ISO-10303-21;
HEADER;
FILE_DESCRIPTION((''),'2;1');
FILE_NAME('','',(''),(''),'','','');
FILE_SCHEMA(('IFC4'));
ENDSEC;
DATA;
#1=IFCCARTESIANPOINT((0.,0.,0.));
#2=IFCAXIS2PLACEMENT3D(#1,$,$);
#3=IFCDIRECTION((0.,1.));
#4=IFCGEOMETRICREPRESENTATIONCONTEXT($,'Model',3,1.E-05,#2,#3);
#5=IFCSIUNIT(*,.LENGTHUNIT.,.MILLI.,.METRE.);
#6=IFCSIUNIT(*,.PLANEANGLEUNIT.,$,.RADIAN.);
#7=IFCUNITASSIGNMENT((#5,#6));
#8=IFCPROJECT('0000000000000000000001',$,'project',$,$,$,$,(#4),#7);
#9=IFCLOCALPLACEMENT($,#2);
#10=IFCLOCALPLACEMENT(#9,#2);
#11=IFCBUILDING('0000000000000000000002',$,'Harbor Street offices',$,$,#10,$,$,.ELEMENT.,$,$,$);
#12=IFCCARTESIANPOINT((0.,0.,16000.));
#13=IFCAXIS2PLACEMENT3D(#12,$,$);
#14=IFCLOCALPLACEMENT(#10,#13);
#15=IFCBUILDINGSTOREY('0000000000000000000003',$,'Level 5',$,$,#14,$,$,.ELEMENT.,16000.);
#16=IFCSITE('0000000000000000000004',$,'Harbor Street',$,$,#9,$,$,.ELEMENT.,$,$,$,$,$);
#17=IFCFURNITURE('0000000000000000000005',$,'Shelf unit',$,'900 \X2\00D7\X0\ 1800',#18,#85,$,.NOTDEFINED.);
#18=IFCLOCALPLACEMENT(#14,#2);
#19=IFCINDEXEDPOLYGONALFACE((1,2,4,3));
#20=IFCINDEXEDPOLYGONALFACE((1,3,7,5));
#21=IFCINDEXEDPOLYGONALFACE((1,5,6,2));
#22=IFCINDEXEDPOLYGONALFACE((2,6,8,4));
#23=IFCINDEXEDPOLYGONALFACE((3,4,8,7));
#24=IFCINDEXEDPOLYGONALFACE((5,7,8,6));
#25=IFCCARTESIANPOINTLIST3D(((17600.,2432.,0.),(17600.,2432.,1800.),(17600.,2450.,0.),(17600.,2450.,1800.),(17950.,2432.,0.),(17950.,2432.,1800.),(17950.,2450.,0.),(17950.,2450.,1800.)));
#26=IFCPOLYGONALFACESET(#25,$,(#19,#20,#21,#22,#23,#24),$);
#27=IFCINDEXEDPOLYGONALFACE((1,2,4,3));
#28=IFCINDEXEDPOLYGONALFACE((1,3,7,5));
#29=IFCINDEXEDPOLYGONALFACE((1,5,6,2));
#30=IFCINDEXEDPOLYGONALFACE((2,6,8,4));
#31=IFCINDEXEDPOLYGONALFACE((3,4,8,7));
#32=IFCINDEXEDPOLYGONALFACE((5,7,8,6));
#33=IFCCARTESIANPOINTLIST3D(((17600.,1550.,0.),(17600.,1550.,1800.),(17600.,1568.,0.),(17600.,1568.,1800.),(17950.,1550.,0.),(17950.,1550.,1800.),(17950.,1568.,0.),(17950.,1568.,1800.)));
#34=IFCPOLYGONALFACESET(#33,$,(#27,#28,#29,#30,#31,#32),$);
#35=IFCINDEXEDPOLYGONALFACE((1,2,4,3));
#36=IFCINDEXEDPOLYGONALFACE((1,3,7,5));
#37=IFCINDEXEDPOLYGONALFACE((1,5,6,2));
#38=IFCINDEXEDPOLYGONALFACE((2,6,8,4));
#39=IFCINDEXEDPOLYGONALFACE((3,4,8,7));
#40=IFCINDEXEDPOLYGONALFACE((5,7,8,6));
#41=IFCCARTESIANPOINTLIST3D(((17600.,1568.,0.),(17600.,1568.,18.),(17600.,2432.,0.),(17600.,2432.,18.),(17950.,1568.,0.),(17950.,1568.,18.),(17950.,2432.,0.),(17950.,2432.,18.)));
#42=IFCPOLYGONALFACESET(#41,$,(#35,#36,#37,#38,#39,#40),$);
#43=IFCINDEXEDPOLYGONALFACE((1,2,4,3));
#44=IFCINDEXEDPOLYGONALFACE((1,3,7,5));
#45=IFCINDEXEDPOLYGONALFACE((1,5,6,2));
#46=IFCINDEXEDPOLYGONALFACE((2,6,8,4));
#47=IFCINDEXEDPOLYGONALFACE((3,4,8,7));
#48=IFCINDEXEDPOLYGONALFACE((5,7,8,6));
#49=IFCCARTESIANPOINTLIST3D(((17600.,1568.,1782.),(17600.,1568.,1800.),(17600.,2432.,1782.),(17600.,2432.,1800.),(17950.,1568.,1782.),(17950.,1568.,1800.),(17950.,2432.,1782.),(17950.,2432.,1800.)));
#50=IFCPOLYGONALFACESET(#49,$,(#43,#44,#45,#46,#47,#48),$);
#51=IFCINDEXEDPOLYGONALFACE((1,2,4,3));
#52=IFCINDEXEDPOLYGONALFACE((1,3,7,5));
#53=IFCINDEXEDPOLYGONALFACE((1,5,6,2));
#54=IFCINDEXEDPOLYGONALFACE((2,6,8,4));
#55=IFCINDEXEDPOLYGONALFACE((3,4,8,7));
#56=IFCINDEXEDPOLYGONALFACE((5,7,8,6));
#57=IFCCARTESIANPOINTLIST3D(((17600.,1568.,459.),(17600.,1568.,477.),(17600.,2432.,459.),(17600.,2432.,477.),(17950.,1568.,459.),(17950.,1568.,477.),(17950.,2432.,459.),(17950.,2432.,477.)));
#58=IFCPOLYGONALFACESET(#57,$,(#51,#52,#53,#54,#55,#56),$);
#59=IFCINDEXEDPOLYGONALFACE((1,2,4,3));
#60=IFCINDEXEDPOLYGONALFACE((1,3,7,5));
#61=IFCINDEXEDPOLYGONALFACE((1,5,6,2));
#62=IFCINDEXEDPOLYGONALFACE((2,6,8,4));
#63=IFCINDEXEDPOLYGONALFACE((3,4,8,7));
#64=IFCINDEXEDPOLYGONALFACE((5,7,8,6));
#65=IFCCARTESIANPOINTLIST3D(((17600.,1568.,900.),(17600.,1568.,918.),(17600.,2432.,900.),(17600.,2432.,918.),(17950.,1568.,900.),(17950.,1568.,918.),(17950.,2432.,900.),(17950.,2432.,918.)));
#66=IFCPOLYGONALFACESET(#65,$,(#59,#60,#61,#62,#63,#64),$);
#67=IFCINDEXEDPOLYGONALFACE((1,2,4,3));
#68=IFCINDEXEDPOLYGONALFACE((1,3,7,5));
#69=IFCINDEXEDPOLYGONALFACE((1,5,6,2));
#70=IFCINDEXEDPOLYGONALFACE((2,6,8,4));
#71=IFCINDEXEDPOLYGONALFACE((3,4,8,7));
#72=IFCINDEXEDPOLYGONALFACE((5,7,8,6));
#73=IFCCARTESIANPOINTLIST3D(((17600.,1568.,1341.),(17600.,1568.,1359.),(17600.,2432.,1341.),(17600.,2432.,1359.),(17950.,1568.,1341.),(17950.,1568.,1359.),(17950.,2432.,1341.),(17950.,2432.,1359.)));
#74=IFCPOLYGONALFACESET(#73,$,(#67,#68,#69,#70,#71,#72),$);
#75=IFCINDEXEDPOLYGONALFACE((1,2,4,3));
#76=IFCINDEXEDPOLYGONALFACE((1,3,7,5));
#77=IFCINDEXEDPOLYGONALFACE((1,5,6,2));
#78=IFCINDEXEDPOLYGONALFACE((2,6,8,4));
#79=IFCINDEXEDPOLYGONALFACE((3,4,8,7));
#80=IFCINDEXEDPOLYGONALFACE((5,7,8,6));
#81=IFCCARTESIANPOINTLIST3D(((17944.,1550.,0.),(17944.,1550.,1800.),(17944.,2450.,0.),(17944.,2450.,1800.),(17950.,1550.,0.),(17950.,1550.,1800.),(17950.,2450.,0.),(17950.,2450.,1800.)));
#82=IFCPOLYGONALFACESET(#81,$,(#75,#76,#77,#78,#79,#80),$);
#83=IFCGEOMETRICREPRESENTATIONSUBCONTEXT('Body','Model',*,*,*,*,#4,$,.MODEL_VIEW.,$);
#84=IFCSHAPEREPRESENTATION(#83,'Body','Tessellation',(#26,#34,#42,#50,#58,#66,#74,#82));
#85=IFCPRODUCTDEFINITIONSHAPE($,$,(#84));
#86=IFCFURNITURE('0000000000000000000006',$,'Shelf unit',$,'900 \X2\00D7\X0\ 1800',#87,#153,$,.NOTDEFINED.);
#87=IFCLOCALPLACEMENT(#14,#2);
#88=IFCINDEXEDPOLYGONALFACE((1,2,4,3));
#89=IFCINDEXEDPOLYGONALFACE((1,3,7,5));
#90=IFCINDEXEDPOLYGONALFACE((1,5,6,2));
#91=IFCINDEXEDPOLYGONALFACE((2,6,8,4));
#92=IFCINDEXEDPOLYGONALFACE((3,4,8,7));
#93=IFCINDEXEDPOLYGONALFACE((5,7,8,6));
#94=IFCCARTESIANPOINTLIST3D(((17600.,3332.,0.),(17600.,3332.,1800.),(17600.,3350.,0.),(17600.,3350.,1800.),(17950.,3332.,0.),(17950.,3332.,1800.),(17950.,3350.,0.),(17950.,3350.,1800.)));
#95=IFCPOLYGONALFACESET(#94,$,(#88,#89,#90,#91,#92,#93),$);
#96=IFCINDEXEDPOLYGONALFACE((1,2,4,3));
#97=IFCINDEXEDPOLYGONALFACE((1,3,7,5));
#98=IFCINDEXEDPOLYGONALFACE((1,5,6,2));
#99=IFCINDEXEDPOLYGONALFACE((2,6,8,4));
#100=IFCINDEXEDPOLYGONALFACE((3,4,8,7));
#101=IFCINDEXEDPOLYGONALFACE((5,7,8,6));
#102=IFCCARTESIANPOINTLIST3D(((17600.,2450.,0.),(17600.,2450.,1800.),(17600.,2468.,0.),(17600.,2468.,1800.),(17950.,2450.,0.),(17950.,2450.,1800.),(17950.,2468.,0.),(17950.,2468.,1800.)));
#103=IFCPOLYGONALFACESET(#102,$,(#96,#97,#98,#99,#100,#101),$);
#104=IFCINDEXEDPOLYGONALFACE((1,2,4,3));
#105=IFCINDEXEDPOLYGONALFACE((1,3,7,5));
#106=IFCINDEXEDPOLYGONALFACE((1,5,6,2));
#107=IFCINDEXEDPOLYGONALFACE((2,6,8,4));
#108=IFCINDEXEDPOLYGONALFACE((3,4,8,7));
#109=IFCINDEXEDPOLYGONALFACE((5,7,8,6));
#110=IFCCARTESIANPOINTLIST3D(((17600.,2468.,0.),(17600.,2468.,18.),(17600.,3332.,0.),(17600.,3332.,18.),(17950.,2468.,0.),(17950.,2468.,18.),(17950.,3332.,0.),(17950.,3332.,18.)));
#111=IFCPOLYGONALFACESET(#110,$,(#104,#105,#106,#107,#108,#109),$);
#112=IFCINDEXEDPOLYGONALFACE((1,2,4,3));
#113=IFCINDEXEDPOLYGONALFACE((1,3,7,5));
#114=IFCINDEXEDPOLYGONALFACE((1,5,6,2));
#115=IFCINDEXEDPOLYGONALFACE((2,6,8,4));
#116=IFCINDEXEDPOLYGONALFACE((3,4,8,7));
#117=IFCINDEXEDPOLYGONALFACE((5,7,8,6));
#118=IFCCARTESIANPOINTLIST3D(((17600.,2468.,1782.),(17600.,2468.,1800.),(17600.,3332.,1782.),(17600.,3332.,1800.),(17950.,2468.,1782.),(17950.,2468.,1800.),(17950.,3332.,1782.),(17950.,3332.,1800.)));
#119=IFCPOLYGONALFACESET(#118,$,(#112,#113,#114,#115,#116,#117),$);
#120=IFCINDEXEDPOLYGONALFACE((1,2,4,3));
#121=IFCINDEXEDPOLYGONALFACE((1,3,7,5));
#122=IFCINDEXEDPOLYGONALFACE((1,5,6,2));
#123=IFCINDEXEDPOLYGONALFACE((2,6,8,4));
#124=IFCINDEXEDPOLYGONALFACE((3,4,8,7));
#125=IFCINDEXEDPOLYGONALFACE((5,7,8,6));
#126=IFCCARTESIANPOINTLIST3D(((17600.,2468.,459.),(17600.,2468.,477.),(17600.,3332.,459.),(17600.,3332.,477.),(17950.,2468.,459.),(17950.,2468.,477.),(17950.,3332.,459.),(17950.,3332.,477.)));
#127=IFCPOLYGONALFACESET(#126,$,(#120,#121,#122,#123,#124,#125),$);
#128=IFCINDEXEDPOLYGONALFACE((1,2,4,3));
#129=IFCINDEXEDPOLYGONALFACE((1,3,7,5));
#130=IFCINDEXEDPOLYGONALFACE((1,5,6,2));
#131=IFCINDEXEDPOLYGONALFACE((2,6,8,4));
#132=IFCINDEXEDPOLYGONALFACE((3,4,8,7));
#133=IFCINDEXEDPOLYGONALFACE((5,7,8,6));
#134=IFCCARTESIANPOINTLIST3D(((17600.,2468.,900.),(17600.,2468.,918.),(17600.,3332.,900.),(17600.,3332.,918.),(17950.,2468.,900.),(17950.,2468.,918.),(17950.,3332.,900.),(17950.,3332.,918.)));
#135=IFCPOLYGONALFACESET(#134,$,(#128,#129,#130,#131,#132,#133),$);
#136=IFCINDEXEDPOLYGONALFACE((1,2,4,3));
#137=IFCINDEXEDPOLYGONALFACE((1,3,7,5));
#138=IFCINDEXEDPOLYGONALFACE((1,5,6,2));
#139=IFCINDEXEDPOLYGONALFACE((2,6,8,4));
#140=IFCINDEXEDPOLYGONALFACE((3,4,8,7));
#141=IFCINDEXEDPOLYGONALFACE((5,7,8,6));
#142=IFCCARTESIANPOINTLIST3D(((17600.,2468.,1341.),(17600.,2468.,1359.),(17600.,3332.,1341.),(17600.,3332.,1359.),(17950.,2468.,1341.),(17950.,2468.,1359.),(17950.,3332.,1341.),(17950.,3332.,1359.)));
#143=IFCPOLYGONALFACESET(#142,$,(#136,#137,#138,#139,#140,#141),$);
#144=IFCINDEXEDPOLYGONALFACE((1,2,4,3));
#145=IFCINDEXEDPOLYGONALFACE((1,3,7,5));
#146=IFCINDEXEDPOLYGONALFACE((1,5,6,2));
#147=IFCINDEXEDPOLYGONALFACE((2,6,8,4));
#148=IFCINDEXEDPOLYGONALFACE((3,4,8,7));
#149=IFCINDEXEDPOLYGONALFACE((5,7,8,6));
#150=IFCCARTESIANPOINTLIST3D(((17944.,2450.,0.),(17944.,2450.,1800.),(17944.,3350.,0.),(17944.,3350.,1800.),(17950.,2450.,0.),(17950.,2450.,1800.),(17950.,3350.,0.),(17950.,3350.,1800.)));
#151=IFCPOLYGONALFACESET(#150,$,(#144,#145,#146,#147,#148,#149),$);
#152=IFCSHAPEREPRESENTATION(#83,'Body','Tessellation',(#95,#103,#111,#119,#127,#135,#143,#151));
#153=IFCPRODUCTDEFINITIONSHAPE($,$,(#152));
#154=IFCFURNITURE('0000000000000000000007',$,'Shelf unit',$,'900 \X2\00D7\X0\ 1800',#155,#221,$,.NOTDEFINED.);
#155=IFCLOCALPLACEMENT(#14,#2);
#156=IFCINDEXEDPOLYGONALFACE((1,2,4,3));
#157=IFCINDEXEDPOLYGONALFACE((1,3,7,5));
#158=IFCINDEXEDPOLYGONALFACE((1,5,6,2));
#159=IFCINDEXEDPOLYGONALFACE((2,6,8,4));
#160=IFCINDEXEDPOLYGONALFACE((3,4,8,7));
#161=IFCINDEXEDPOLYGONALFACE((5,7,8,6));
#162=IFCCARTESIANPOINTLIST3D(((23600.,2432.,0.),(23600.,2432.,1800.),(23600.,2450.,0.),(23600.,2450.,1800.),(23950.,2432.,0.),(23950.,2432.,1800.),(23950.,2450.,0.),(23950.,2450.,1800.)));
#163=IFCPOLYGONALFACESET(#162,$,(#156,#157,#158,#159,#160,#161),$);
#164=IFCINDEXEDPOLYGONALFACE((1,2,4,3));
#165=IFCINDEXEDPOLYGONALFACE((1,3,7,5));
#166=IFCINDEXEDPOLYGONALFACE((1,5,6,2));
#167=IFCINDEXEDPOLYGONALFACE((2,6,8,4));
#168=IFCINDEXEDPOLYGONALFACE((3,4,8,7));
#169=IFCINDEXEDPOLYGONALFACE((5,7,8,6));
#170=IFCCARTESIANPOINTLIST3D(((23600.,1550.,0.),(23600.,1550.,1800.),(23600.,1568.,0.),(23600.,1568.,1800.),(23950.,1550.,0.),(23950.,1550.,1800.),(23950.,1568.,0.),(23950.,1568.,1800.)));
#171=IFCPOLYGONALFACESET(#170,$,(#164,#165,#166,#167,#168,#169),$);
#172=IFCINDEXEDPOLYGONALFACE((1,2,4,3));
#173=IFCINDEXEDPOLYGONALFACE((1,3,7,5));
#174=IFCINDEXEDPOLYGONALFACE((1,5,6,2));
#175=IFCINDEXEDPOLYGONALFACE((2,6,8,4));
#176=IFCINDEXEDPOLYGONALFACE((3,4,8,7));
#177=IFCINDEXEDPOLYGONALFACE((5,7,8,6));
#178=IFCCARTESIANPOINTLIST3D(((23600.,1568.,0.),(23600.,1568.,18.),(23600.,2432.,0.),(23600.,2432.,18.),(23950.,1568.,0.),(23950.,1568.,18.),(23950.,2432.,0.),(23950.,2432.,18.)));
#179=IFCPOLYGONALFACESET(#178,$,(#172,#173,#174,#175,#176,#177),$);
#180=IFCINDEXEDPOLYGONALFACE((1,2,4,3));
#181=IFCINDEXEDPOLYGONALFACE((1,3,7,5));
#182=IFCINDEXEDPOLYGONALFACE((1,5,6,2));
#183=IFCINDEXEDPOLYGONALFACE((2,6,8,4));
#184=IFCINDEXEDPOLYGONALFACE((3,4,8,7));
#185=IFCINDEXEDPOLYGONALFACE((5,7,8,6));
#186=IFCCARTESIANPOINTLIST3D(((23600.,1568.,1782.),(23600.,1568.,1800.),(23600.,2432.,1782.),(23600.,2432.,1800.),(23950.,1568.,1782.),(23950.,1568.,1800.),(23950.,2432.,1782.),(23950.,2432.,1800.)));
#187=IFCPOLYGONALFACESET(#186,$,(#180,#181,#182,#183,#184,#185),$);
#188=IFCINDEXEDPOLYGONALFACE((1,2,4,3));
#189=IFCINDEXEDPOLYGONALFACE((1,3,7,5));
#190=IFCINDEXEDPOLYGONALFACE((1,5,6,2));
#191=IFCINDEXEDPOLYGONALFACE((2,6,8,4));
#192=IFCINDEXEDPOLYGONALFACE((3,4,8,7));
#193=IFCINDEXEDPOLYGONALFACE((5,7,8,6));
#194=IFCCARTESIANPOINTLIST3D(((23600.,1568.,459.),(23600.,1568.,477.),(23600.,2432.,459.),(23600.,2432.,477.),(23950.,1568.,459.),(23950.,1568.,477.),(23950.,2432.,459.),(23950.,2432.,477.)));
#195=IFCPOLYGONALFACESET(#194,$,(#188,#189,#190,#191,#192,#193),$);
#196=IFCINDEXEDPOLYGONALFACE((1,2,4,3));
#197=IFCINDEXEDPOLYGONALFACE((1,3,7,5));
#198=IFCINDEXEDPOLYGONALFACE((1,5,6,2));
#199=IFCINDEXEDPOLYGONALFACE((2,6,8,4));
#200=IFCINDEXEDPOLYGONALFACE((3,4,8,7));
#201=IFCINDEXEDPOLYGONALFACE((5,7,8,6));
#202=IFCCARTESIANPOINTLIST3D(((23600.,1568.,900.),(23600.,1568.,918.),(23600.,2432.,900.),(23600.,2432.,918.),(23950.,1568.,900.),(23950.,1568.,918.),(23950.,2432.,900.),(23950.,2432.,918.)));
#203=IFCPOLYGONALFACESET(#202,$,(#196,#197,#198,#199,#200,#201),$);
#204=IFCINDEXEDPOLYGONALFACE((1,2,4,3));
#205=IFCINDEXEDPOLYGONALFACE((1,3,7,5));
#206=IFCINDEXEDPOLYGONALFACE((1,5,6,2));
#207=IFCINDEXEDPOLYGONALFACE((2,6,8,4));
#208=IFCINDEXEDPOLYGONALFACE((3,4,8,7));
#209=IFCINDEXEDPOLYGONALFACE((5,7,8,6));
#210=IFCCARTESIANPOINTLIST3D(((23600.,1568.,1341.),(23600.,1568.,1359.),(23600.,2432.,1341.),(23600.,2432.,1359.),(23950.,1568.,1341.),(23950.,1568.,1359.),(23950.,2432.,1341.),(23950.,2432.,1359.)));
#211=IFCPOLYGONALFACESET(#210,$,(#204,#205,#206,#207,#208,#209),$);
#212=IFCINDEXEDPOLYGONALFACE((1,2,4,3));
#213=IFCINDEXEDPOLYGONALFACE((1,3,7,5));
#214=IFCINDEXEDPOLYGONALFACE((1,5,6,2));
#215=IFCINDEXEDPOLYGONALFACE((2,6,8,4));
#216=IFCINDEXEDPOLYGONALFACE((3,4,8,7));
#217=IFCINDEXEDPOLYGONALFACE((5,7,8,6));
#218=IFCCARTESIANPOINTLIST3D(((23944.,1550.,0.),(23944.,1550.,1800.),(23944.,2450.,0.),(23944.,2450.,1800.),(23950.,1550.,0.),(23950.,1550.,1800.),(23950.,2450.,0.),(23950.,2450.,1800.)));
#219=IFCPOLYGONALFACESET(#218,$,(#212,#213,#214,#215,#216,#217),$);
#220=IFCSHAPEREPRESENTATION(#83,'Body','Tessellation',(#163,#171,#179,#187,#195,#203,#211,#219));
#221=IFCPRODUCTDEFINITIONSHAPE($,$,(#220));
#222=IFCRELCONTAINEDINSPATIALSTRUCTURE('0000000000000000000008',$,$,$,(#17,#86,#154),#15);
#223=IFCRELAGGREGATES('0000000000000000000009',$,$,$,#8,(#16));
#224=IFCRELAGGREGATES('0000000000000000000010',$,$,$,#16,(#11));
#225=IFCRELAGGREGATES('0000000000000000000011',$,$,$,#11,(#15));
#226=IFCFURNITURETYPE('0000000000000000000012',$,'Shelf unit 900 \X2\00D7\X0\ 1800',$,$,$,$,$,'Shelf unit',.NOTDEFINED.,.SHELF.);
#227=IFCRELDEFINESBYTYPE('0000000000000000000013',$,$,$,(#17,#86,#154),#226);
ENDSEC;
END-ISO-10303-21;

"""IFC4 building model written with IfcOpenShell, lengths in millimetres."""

from ifc_helpers import new_model, si_unit, direction, frame, origin, place, context, subcontext, project, spatial, polyline, outline, extrude, source, transform, mapped, type_object, type_shapes, element, save


model = new_model("IFC4")

# Units and contexts
model_context = context("Model", 3, precision=1e-05, world=origin(), true_north=direction((0.0, 1.0)))
body_context = subcontext(model_context, "Body", "Model", "MODEL_VIEW")
ifc_project = project(units=[si_unit("LENGTHUNIT", "METRE", prefix="MILLI"), si_unit("PLANEANGLEUNIT", "RADIAN")], contexts=[model_context])

# Site, building, storey
site_placement = place(None, origin())
site = spatial("IfcSite", under=ifc_project, at=site_placement, Name="Harbor Street", CompositionType="ELEMENT")
building_placement = place(site_placement, origin())
building = spatial("IfcBuilding", under=site, at=building_placement, Name="Harbor Street offices", CompositionType="ELEMENT")
storey_placement = place(building_placement, frame((0.0, 0.0, 16000.0)))
storey = spatial("IfcBuildingStorey", under=building, at=storey_placement, Name="Level 5", CompositionType="ELEMENT", Elevation=16000.0)

# Furniture
furniture_type_1 = type_object("IfcFurnitureType", Name="Shelf unit 900 × 1800", ElementType="Shelf unit", AssemblyPlace="NOTDEFINED", PredefinedType="SHELF")
shared_shape_1 = source(origin(), body_context, "Body", "SweptSolid", [
    extrude(outline(polyline([(-450.0, 0.0), (-432.0, 0.0), (-432.0, 350.0), (-450.0, 350.0), (-450.0, 0.0)])), origin(), (0.0, 0.0, 1.0), 1800.0),
    extrude(outline(polyline([(432.0, 0.0), (450.0, 0.0), (450.0, 350.0), (432.0, 350.0), (432.0, 0.0)])), origin(), (0.0, 0.0, 1.0), 1800.0),
    extrude(outline(polyline([(-432.0, 0.0), (432.0, 0.0), (432.0, 350.0), (-432.0, 350.0), (-432.0, 0.0)])), origin(), (0.0, 0.0, 1.0), 18.0),
    extrude(outline(polyline([(-432.0, 0.0), (432.0, 0.0), (432.0, 350.0), (-432.0, 350.0), (-432.0, 0.0)])), frame((0.0, 0.0, 1782.0)), (0.0, 0.0, 1.0), 18.0),
    extrude(outline(polyline([(-432.0, 0.0), (432.0, 0.0), (432.0, 350.0), (-432.0, 350.0), (-432.0, 0.0)])), frame((0.0, 0.0, 459.0)), (0.0, 0.0, 1.0), 18.0),
    extrude(outline(polyline([(-432.0, 0.0), (432.0, 0.0), (432.0, 350.0), (-432.0, 350.0), (-432.0, 0.0)])), frame((0.0, 0.0, 900.0)), (0.0, 0.0, 1.0), 18.0),
    extrude(outline(polyline([(-432.0, 0.0), (432.0, 0.0), (432.0, 350.0), (-432.0, 350.0), (-432.0, 0.0)])), frame((0.0, 0.0, 1341.0)), (0.0, 0.0, 1.0), 18.0),
    extrude(outline(polyline([(-450.0, 344.0), (450.0, 344.0), (450.0, 350.0), (-450.0, 350.0), (-450.0, 344.0)])), origin(), (0.0, 0.0, 1.0), 1800.0),
])
type_shapes(furniture_type_1, [shared_shape_1])
for number, where, z_axis, x_axis, name in (
    (1, (17600.0, 2000.0, 0.0), (0.0, 0.0, 1.0), (0.0, -1.0, 0.0), "Shelf unit"),
    (2, (17600.0, 2900.0, 0.0), (0.0, 0.0, 1.0), (0.0, -1.0, 0.0), "Shelf unit"),
    (3, (23600.0, 2000.0, 0.0), (0.0, 0.0, 1.0), (0.0, -1.0, 0.0), "Shelf unit"),
):
    element("IfcFurniture", number, at=place(storey_placement, frame(where, z_axis=z_axis, x_axis=x_axis)), inside=storey, type_object=furniture_type_1, Name=name, ObjectType="900 × 1800", PredefinedType="NOTDEFINED", context=body_context, shape_type="MappedRepresentation", body=[
        mapped(shared_shape_1, transform((0.0, 0.0, 0.0))),
    ])

save(model, "model.ifc")
